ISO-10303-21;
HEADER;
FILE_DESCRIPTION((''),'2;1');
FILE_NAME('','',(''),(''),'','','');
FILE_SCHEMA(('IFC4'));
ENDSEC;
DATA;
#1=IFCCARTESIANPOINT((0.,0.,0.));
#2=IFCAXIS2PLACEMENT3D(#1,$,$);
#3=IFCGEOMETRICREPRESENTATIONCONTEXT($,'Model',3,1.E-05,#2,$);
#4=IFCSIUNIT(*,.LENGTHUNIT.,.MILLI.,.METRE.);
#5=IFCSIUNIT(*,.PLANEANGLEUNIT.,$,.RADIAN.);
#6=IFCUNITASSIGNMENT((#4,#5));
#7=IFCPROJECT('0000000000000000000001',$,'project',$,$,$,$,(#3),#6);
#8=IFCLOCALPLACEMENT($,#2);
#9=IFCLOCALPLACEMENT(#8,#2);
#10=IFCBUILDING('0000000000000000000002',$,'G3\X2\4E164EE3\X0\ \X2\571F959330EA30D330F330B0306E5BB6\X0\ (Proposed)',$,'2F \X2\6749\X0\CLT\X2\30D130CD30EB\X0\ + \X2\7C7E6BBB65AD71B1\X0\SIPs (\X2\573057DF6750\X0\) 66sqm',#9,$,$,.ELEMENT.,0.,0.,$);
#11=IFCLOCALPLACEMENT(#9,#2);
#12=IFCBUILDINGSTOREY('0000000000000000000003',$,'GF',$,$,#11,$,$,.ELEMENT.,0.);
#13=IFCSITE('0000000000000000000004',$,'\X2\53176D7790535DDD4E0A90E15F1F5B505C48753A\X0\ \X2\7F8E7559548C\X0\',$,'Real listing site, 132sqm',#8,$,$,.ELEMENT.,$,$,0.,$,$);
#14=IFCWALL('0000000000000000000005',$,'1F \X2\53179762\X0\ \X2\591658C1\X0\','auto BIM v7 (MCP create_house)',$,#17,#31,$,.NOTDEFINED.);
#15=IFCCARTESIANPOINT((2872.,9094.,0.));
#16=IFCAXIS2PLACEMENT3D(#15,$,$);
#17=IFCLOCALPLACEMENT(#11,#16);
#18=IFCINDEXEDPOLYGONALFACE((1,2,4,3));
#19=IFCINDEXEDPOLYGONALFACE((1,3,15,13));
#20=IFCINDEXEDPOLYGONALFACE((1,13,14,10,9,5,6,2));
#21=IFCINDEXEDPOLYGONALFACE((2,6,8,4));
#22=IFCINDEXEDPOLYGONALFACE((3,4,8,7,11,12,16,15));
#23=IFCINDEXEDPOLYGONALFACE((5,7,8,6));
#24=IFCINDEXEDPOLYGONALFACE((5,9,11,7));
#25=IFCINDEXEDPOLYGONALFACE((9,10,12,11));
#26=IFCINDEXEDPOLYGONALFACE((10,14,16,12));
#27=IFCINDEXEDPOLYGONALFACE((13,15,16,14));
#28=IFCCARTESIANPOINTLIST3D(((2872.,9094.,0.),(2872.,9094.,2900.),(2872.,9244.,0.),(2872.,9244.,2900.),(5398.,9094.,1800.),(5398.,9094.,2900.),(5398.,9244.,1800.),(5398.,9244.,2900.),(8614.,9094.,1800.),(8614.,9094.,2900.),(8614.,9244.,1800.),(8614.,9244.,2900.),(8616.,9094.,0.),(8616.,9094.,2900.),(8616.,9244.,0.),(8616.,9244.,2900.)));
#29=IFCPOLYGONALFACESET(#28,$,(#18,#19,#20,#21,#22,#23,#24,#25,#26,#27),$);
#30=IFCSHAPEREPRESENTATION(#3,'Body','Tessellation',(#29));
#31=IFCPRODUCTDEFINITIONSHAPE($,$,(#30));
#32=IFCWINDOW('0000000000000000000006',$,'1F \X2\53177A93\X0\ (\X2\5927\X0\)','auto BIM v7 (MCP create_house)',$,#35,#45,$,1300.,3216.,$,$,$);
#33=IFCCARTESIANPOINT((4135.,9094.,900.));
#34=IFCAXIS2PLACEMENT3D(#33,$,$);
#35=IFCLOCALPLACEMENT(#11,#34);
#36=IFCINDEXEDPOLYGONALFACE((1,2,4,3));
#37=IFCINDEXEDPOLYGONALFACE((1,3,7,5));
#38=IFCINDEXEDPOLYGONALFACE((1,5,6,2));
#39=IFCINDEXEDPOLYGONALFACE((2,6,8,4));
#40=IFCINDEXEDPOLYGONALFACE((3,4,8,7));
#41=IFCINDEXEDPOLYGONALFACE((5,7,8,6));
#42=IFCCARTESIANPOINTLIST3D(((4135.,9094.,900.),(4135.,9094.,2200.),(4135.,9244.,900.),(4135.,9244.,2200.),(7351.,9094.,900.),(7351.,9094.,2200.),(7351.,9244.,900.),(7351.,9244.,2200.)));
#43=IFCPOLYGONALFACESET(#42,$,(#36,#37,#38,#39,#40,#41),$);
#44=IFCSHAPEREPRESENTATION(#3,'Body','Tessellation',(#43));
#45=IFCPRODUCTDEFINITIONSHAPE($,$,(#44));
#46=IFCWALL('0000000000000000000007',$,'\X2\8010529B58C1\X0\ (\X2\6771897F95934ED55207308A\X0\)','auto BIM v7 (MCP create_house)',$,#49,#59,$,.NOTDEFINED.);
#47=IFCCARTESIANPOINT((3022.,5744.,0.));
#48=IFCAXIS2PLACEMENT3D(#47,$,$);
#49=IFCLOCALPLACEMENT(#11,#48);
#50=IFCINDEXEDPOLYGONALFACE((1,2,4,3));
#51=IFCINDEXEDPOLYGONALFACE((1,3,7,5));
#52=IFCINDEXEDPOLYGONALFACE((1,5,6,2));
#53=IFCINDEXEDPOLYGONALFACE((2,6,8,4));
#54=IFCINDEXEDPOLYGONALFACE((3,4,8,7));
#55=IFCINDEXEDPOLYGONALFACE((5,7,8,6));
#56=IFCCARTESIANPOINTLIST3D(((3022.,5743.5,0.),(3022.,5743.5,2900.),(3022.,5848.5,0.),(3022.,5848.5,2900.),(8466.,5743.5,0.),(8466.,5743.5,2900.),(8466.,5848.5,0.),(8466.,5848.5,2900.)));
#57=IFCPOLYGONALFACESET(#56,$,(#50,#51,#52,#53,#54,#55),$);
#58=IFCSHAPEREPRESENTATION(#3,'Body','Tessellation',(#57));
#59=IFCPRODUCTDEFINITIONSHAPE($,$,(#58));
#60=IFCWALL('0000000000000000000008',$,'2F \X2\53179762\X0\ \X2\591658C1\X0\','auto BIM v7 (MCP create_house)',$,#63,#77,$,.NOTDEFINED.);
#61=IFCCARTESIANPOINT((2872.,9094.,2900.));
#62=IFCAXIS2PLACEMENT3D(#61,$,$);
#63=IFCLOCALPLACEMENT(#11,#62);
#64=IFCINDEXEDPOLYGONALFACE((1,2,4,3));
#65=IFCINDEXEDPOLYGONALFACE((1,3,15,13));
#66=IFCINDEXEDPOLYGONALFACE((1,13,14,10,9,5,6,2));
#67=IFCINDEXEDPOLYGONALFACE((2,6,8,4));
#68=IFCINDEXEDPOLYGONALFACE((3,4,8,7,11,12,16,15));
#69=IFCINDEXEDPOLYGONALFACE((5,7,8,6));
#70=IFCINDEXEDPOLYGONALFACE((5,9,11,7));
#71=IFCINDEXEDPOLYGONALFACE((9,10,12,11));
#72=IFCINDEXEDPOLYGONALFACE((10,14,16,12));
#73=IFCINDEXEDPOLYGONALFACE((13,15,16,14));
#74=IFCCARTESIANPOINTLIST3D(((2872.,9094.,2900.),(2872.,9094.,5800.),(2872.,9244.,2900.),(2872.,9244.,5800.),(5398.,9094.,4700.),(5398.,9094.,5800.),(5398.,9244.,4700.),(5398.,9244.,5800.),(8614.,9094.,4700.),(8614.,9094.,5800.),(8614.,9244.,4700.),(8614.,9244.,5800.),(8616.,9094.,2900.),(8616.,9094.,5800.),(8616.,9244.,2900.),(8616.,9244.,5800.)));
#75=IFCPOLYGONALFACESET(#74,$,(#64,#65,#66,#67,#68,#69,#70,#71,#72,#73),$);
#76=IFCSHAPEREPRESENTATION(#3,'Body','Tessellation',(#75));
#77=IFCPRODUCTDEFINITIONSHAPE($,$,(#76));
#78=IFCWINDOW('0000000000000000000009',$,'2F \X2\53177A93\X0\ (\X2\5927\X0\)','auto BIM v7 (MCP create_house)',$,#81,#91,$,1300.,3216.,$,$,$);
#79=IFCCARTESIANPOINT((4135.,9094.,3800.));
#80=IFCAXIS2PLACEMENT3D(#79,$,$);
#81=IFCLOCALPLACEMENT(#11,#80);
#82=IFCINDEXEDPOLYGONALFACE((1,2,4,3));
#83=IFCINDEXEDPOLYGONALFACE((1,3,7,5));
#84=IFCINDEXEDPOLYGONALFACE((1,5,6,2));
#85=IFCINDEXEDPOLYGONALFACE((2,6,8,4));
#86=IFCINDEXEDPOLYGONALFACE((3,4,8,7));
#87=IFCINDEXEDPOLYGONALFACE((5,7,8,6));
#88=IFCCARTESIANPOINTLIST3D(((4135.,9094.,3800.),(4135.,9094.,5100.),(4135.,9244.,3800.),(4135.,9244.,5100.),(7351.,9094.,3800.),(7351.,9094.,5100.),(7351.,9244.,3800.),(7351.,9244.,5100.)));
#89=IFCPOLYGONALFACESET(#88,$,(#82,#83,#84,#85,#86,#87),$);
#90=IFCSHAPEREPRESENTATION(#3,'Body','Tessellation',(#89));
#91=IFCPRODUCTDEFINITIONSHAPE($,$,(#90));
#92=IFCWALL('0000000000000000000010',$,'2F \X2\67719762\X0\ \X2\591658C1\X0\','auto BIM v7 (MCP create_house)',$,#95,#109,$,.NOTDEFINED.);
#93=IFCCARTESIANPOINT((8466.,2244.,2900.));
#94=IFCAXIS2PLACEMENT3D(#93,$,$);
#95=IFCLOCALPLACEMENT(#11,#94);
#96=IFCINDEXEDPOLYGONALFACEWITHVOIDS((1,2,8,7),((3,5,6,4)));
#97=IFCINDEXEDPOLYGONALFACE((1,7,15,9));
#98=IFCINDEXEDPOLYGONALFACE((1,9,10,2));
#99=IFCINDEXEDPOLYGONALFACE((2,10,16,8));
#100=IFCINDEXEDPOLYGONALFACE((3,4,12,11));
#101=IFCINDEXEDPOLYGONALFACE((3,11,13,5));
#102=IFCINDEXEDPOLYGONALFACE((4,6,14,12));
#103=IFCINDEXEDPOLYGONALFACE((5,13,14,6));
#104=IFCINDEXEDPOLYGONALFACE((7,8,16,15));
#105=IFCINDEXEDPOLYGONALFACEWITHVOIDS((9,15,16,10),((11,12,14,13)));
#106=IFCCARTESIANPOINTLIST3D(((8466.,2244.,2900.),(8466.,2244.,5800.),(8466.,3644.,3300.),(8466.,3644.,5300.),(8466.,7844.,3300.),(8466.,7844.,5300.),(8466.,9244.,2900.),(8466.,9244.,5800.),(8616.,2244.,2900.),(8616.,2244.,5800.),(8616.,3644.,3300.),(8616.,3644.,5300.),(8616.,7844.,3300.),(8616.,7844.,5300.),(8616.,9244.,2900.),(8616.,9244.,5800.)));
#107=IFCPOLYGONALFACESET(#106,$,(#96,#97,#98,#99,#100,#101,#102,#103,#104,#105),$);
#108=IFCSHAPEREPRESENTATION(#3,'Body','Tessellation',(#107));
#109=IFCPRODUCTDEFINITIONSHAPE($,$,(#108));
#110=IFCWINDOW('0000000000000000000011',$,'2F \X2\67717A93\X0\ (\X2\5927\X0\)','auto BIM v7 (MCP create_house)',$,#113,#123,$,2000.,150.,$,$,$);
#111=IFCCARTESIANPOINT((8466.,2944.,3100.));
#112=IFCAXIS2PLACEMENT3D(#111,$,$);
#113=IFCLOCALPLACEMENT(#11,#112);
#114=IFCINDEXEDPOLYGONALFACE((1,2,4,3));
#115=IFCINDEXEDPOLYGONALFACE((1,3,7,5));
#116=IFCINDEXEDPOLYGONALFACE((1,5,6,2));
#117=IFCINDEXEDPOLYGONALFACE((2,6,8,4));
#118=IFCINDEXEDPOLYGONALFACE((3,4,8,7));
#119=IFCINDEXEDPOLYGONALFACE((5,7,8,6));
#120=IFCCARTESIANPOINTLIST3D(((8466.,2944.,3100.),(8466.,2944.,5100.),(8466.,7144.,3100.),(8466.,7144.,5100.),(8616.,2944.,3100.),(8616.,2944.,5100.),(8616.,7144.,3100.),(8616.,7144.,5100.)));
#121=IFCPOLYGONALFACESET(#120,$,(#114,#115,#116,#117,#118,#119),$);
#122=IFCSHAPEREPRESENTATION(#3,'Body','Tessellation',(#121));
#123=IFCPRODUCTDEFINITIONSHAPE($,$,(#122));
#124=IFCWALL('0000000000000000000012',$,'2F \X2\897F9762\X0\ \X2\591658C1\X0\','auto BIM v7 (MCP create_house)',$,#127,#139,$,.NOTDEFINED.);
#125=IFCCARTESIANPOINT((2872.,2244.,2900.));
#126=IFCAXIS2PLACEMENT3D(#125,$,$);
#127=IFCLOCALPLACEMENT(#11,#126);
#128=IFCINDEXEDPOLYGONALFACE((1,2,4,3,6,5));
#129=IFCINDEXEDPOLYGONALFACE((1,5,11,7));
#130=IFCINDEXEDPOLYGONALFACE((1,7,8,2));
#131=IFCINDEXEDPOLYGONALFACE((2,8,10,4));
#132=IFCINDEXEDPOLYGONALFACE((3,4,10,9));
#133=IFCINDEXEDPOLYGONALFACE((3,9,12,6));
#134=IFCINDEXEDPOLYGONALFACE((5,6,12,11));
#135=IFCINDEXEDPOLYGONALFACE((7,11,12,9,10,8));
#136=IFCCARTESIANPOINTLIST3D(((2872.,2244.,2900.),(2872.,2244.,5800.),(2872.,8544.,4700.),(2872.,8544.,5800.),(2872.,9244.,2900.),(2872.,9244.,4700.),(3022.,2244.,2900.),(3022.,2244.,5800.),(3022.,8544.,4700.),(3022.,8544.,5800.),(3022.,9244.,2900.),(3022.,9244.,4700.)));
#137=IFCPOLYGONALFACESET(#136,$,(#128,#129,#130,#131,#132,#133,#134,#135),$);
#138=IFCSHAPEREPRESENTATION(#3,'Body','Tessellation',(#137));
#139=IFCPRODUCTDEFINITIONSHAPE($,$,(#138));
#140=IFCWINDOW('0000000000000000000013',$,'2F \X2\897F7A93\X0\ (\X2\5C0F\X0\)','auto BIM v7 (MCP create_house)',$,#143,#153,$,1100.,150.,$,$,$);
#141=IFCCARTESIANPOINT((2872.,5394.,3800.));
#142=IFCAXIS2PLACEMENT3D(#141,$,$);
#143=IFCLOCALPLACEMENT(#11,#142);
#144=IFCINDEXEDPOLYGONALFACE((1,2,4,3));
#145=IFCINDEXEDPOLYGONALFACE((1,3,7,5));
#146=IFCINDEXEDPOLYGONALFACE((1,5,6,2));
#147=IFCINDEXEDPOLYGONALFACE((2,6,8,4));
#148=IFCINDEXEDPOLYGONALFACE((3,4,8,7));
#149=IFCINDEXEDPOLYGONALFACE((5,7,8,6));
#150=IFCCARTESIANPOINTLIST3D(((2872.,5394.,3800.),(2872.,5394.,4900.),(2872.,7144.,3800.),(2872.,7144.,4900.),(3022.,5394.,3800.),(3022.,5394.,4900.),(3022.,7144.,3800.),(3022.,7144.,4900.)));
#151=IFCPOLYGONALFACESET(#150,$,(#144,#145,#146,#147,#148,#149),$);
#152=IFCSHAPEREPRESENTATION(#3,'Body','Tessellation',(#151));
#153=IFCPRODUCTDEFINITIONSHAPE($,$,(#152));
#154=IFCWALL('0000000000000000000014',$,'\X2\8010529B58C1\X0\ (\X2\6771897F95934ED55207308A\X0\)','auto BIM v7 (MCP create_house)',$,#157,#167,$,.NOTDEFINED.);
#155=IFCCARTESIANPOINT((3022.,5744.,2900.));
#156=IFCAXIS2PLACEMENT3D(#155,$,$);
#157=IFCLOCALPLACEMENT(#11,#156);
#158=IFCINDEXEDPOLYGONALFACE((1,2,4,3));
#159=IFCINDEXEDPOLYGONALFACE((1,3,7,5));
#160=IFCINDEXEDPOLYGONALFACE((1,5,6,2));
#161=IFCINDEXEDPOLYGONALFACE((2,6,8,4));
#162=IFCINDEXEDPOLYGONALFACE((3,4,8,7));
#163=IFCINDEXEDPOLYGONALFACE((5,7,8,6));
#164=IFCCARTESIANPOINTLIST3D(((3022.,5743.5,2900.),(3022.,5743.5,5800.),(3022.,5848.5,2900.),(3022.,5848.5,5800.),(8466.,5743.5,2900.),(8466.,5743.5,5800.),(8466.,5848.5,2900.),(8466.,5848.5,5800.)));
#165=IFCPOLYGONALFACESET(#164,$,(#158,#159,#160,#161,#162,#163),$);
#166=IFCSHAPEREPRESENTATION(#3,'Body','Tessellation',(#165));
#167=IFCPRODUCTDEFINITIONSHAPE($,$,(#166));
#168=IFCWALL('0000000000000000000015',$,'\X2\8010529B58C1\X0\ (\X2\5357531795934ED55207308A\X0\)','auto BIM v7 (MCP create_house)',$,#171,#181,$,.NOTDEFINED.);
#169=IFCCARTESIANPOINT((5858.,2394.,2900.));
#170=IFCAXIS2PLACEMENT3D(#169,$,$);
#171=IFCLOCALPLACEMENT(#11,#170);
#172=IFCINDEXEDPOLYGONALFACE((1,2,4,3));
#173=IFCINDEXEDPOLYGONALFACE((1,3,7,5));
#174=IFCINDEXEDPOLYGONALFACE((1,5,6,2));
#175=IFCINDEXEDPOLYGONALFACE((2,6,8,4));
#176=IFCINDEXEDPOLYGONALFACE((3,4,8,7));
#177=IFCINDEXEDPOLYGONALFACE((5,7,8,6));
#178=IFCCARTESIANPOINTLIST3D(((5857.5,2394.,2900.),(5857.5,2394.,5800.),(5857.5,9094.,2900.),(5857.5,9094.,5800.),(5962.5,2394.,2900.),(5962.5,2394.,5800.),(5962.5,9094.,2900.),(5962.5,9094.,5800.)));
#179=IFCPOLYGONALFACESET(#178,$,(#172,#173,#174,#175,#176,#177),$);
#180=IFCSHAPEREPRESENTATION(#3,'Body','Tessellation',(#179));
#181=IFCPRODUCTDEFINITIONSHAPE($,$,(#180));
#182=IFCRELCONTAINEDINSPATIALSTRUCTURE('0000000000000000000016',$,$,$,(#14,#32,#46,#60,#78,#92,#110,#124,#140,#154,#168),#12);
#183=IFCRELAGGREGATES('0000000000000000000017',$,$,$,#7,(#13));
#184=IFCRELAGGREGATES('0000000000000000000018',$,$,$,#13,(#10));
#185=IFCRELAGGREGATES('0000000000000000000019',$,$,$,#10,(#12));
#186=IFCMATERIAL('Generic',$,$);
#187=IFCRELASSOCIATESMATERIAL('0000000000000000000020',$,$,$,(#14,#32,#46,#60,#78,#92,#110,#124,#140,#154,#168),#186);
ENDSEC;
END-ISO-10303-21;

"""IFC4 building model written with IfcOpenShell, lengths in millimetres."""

from ifc_helpers import new_model, si_unit, frame, frame_2d, origin, place, context, project, spatial, rectangle, extrude, material, element, fill, save


model = new_model("IFC4")

# Units and contexts
model_context = context("Model", 3, precision=1e-05, world=origin())
ifc_project = project(units=[si_unit("LENGTHUNIT", "METRE", prefix="MILLI"), si_unit("PLANEANGLEUNIT", "RADIAN")], contexts=[model_context])

# Site, building, storey
site_placement = place(None, origin())
site = spatial("IfcSite", under=ifc_project, at=site_placement, Name="北海道川上郡弟子屈町 美留和", ObjectType="Real listing site, 132sqm", CompositionType="ELEMENT", RefElevation=0.0)
building_placement = place(site_placement, origin())
building = spatial("IfcBuilding", under=site, at=building_placement, Name="G3世代 土間リビングの家 (Proposed)", ObjectType="2F 杉CLTパネル + 籾殻断熱SIPs (地域材) 66sqm", CompositionType="ELEMENT", ElevationOfRefHeight=0.0, ElevationOfTerrain=0.0)
storey_placement = place(building_placement, origin())
storey = spatial("IfcBuildingStorey", under=building, at=storey_placement, Name="GF", CompositionType="ELEMENT", Elevation=0.0)

# Wall, opening, window
ifc_material = material(Name="Generic")
wall_1_placement = place(storey_placement, frame((2872.0, 9094.0, 0.0)))
wall_1 = element("IfcWall", 1, at=wall_1_placement, inside=storey, material=ifc_material, Name="1F 北面 外壁", Description="auto BIM v7 (MCP create_house)", PredefinedType="NOTDEFINED", context=model_context, shape_type="SweptSolid", body=[
    extrude(rectangle(XDim=5744.0, YDim=150.0, at=frame_2d((2872.0, 75.0))), frame((2872.0, 9094.0, 0.0)), (0.0, 0.0, 1.0), 2900.0),
])
opening_1_placement = place(storey_placement, frame((4135.0, 9094.0, 900.0)))
opening_1 = element("IfcOpeningElement", 2, at=opening_1_placement, cuts=wall_1, PredefinedType="NOTDEFINED", context=model_context, shape_type="SweptSolid", body=[
    extrude(rectangle(XDim=3216.0, YDim=150.0, at=frame_2d((1608.0, 75.0))), frame((4135.0, 9094.0, 900.0)), (0.0, 0.0, 1.0), 1300.0),
])
window_1_placement = place(storey_placement, frame((4135.0, 9094.0, 900.0)))
window_1 = element("IfcWindow", 3, at=window_1_placement, inside=storey, material=ifc_material, Name="1F 北窓 (大)", Description="auto BIM v7 (MCP create_house)", OverallHeight=1300.0, OverallWidth=3216.0, context=model_context, shape_type="SweptSolid", body=[
    extrude(rectangle(XDim=3216.0, YDim=150.0, at=frame_2d((1608.0, 75.0))), frame((4135.0, 9094.0, 900.0)), (0.0, 0.0, 1.0), 1300.0),
])
fill(opening_1, window_1)

# Wall
wall_2_placement = place(storey_placement, frame((3022.0, 5744.0, 0.0)))
element("IfcWall", 4, at=wall_2_placement, inside=storey, material=ifc_material, Name="耐力壁 (東西間仕切り)", Description="auto BIM v7 (MCP create_house)", PredefinedType="NOTDEFINED", context=model_context, shape_type="SweptSolid", body=[
    extrude(rectangle(XDim=5444.0, YDim=105.0, at=frame_2d((2722.0, 52.0))), frame((3022.0, 5744.0, 0.0)), (0.0, 0.0, 1.0), 2900.0),
])

# Walls, openings, windows
wall_3_placement = place(storey_placement, frame((2872.0, 9094.0, 2900.0)))
wall_3 = element("IfcWall", 5, at=wall_3_placement, inside=storey, material=ifc_material, Name="2F 北面 外壁", Description="auto BIM v7 (MCP create_house)", PredefinedType="NOTDEFINED", context=model_context, shape_type="SweptSolid", body=[
    extrude(rectangle(XDim=5744.0, YDim=150.0, at=frame_2d((2872.0, 75.0))), frame((2872.0, 9094.0, 2900.0)), (0.0, 0.0, 1.0), 2900.0),
])
opening_2_placement = place(storey_placement, frame((4135.0, 9094.0, 3800.0)))
opening_2 = element("IfcOpeningElement", 6, at=opening_2_placement, cuts=wall_3, PredefinedType="NOTDEFINED", context=model_context, shape_type="SweptSolid", body=[
    extrude(rectangle(XDim=3216.0, YDim=150.0, at=frame_2d((1608.0, 75.0))), frame((4135.0, 9094.0, 3800.0)), (0.0, 0.0, 1.0), 1300.0),
])
window_2_placement = place(storey_placement, frame((4135.0, 9094.0, 3800.0)))
window_2 = element("IfcWindow", 7, at=window_2_placement, inside=storey, material=ifc_material, Name="2F 北窓 (大)", Description="auto BIM v7 (MCP create_house)", OverallHeight=1300.0, OverallWidth=3216.0, context=model_context, shape_type="SweptSolid", body=[
    extrude(rectangle(XDim=3216.0, YDim=150.0, at=frame_2d((1608.0, 75.0))), frame((4135.0, 9094.0, 3800.0)), (0.0, 0.0, 1.0), 1300.0),
])
fill(opening_2, window_2)
wall_4_placement = place(storey_placement, frame((8466.0, 2244.0, 2900.0)))
wall_4 = element("IfcWall", 8, at=wall_4_placement, inside=storey, material=ifc_material, Name="2F 東面 外壁", Description="auto BIM v7 (MCP create_house)", PredefinedType="NOTDEFINED", context=model_context, shape_type="SweptSolid", body=[
    extrude(rectangle(XDim=150.0, YDim=7000.0, at=frame_2d((75.0, 3500.0))), frame((8466.0, 2244.0, 2900.0)), (0.0, 0.0, 1.0), 2900.0),
])
opening_3_placement = place(storey_placement, frame((8466.0, 2944.0, 3100.0)))
opening_3 = element("IfcOpeningElement", 9, at=opening_3_placement, cuts=wall_4, PredefinedType="NOTDEFINED", context=model_context, shape_type="SweptSolid", body=[
    extrude(rectangle(XDim=150.0, YDim=4200.0, at=frame_2d((75.0, 2100.0))), frame((8466.0, 2944.0, 3100.0)), (0.0, 0.0, 1.0), 2000.0),
])
window_3_placement = place(storey_placement, frame((8466.0, 2944.0, 3100.0)))
window_3 = element("IfcWindow", 10, at=window_3_placement, inside=storey, material=ifc_material, Name="2F 東窓 (大)", Description="auto BIM v7 (MCP create_house)", OverallHeight=2000.0, OverallWidth=150.0, context=model_context, shape_type="SweptSolid", body=[
    extrude(rectangle(XDim=150.0, YDim=4200.0, at=frame_2d((75.0, 2100.0))), frame((8466.0, 2944.0, 3100.0)), (0.0, 0.0, 1.0), 2000.0),
])
fill(opening_3, window_3)
wall_5_placement = place(storey_placement, frame((2872.0, 2244.0, 2900.0)))
wall_5 = element("IfcWall", 11, at=wall_5_placement, inside=storey, material=ifc_material, Name="2F 西面 外壁", Description="auto BIM v7 (MCP create_house)", PredefinedType="NOTDEFINED", context=model_context, shape_type="SweptSolid", body=[
    extrude(rectangle(XDim=150.0, YDim=7000.0, at=frame_2d((75.0, 3500.0))), frame((2872.0, 2244.0, 2900.0)), (0.0, 0.0, 1.0), 2900.0),
])
opening_4_placement = place(storey_placement, frame((2872.0, 5394.0, 3800.0)))
opening_4 = element("IfcOpeningElement", 12, at=opening_4_placement, cuts=wall_5, PredefinedType="NOTDEFINED", context=model_context, shape_type="SweptSolid", body=[
    extrude(rectangle(XDim=150.0, YDim=1750.0, at=frame_2d((75.0, 875.0))), frame((2872.0, 5394.0, 3800.0)), (0.0, 0.0, 1.0), 1100.0),
])
window_4_placement = place(storey_placement, frame((2872.0, 5394.0, 3800.0)))
window_4 = element("IfcWindow", 13, at=window_4_placement, inside=storey, material=ifc_material, Name="2F 西窓 (小)", Description="auto BIM v7 (MCP create_house)", OverallHeight=1100.0, OverallWidth=150.0, context=model_context, shape_type="SweptSolid", body=[
    extrude(rectangle(XDim=150.0, YDim=1750.0, at=frame_2d((75.0, 875.0))), frame((2872.0, 5394.0, 3800.0)), (0.0, 0.0, 1.0), 1100.0),
])
fill(opening_4, window_4)

# Walls
wall_6_placement = place(storey_placement, frame((3022.0, 5744.0, 2900.0)))
element("IfcWall", 14, at=wall_6_placement, inside=storey, material=ifc_material, Name="耐力壁 (東西間仕切り)", Description="auto BIM v7 (MCP create_house)", PredefinedType="NOTDEFINED", context=model_context, shape_type="SweptSolid", body=[
    extrude(rectangle(XDim=5444.0, YDim=105.0, at=frame_2d((2722.0, 52.0))), frame((3022.0, 5744.0, 2900.0)), (0.0, 0.0, 1.0), 2900.0),
])
wall_7_placement = place(storey_placement, frame((5858.0, 2394.0, 2900.0)))
element("IfcWall", 15, at=wall_7_placement, inside=storey, material=ifc_material, Name="耐力壁 (南北間仕切り)", Description="auto BIM v7 (MCP create_house)", PredefinedType="NOTDEFINED", context=model_context, shape_type="SweptSolid", body=[
    extrude(rectangle(XDim=105.0, YDim=6700.0, at=frame_2d((52.0, 3350.0))), frame((5858.0, 2394.0, 2900.0)), (0.0, 0.0, 1.0), 2900.0),
])

save(model, "model.ifc")
